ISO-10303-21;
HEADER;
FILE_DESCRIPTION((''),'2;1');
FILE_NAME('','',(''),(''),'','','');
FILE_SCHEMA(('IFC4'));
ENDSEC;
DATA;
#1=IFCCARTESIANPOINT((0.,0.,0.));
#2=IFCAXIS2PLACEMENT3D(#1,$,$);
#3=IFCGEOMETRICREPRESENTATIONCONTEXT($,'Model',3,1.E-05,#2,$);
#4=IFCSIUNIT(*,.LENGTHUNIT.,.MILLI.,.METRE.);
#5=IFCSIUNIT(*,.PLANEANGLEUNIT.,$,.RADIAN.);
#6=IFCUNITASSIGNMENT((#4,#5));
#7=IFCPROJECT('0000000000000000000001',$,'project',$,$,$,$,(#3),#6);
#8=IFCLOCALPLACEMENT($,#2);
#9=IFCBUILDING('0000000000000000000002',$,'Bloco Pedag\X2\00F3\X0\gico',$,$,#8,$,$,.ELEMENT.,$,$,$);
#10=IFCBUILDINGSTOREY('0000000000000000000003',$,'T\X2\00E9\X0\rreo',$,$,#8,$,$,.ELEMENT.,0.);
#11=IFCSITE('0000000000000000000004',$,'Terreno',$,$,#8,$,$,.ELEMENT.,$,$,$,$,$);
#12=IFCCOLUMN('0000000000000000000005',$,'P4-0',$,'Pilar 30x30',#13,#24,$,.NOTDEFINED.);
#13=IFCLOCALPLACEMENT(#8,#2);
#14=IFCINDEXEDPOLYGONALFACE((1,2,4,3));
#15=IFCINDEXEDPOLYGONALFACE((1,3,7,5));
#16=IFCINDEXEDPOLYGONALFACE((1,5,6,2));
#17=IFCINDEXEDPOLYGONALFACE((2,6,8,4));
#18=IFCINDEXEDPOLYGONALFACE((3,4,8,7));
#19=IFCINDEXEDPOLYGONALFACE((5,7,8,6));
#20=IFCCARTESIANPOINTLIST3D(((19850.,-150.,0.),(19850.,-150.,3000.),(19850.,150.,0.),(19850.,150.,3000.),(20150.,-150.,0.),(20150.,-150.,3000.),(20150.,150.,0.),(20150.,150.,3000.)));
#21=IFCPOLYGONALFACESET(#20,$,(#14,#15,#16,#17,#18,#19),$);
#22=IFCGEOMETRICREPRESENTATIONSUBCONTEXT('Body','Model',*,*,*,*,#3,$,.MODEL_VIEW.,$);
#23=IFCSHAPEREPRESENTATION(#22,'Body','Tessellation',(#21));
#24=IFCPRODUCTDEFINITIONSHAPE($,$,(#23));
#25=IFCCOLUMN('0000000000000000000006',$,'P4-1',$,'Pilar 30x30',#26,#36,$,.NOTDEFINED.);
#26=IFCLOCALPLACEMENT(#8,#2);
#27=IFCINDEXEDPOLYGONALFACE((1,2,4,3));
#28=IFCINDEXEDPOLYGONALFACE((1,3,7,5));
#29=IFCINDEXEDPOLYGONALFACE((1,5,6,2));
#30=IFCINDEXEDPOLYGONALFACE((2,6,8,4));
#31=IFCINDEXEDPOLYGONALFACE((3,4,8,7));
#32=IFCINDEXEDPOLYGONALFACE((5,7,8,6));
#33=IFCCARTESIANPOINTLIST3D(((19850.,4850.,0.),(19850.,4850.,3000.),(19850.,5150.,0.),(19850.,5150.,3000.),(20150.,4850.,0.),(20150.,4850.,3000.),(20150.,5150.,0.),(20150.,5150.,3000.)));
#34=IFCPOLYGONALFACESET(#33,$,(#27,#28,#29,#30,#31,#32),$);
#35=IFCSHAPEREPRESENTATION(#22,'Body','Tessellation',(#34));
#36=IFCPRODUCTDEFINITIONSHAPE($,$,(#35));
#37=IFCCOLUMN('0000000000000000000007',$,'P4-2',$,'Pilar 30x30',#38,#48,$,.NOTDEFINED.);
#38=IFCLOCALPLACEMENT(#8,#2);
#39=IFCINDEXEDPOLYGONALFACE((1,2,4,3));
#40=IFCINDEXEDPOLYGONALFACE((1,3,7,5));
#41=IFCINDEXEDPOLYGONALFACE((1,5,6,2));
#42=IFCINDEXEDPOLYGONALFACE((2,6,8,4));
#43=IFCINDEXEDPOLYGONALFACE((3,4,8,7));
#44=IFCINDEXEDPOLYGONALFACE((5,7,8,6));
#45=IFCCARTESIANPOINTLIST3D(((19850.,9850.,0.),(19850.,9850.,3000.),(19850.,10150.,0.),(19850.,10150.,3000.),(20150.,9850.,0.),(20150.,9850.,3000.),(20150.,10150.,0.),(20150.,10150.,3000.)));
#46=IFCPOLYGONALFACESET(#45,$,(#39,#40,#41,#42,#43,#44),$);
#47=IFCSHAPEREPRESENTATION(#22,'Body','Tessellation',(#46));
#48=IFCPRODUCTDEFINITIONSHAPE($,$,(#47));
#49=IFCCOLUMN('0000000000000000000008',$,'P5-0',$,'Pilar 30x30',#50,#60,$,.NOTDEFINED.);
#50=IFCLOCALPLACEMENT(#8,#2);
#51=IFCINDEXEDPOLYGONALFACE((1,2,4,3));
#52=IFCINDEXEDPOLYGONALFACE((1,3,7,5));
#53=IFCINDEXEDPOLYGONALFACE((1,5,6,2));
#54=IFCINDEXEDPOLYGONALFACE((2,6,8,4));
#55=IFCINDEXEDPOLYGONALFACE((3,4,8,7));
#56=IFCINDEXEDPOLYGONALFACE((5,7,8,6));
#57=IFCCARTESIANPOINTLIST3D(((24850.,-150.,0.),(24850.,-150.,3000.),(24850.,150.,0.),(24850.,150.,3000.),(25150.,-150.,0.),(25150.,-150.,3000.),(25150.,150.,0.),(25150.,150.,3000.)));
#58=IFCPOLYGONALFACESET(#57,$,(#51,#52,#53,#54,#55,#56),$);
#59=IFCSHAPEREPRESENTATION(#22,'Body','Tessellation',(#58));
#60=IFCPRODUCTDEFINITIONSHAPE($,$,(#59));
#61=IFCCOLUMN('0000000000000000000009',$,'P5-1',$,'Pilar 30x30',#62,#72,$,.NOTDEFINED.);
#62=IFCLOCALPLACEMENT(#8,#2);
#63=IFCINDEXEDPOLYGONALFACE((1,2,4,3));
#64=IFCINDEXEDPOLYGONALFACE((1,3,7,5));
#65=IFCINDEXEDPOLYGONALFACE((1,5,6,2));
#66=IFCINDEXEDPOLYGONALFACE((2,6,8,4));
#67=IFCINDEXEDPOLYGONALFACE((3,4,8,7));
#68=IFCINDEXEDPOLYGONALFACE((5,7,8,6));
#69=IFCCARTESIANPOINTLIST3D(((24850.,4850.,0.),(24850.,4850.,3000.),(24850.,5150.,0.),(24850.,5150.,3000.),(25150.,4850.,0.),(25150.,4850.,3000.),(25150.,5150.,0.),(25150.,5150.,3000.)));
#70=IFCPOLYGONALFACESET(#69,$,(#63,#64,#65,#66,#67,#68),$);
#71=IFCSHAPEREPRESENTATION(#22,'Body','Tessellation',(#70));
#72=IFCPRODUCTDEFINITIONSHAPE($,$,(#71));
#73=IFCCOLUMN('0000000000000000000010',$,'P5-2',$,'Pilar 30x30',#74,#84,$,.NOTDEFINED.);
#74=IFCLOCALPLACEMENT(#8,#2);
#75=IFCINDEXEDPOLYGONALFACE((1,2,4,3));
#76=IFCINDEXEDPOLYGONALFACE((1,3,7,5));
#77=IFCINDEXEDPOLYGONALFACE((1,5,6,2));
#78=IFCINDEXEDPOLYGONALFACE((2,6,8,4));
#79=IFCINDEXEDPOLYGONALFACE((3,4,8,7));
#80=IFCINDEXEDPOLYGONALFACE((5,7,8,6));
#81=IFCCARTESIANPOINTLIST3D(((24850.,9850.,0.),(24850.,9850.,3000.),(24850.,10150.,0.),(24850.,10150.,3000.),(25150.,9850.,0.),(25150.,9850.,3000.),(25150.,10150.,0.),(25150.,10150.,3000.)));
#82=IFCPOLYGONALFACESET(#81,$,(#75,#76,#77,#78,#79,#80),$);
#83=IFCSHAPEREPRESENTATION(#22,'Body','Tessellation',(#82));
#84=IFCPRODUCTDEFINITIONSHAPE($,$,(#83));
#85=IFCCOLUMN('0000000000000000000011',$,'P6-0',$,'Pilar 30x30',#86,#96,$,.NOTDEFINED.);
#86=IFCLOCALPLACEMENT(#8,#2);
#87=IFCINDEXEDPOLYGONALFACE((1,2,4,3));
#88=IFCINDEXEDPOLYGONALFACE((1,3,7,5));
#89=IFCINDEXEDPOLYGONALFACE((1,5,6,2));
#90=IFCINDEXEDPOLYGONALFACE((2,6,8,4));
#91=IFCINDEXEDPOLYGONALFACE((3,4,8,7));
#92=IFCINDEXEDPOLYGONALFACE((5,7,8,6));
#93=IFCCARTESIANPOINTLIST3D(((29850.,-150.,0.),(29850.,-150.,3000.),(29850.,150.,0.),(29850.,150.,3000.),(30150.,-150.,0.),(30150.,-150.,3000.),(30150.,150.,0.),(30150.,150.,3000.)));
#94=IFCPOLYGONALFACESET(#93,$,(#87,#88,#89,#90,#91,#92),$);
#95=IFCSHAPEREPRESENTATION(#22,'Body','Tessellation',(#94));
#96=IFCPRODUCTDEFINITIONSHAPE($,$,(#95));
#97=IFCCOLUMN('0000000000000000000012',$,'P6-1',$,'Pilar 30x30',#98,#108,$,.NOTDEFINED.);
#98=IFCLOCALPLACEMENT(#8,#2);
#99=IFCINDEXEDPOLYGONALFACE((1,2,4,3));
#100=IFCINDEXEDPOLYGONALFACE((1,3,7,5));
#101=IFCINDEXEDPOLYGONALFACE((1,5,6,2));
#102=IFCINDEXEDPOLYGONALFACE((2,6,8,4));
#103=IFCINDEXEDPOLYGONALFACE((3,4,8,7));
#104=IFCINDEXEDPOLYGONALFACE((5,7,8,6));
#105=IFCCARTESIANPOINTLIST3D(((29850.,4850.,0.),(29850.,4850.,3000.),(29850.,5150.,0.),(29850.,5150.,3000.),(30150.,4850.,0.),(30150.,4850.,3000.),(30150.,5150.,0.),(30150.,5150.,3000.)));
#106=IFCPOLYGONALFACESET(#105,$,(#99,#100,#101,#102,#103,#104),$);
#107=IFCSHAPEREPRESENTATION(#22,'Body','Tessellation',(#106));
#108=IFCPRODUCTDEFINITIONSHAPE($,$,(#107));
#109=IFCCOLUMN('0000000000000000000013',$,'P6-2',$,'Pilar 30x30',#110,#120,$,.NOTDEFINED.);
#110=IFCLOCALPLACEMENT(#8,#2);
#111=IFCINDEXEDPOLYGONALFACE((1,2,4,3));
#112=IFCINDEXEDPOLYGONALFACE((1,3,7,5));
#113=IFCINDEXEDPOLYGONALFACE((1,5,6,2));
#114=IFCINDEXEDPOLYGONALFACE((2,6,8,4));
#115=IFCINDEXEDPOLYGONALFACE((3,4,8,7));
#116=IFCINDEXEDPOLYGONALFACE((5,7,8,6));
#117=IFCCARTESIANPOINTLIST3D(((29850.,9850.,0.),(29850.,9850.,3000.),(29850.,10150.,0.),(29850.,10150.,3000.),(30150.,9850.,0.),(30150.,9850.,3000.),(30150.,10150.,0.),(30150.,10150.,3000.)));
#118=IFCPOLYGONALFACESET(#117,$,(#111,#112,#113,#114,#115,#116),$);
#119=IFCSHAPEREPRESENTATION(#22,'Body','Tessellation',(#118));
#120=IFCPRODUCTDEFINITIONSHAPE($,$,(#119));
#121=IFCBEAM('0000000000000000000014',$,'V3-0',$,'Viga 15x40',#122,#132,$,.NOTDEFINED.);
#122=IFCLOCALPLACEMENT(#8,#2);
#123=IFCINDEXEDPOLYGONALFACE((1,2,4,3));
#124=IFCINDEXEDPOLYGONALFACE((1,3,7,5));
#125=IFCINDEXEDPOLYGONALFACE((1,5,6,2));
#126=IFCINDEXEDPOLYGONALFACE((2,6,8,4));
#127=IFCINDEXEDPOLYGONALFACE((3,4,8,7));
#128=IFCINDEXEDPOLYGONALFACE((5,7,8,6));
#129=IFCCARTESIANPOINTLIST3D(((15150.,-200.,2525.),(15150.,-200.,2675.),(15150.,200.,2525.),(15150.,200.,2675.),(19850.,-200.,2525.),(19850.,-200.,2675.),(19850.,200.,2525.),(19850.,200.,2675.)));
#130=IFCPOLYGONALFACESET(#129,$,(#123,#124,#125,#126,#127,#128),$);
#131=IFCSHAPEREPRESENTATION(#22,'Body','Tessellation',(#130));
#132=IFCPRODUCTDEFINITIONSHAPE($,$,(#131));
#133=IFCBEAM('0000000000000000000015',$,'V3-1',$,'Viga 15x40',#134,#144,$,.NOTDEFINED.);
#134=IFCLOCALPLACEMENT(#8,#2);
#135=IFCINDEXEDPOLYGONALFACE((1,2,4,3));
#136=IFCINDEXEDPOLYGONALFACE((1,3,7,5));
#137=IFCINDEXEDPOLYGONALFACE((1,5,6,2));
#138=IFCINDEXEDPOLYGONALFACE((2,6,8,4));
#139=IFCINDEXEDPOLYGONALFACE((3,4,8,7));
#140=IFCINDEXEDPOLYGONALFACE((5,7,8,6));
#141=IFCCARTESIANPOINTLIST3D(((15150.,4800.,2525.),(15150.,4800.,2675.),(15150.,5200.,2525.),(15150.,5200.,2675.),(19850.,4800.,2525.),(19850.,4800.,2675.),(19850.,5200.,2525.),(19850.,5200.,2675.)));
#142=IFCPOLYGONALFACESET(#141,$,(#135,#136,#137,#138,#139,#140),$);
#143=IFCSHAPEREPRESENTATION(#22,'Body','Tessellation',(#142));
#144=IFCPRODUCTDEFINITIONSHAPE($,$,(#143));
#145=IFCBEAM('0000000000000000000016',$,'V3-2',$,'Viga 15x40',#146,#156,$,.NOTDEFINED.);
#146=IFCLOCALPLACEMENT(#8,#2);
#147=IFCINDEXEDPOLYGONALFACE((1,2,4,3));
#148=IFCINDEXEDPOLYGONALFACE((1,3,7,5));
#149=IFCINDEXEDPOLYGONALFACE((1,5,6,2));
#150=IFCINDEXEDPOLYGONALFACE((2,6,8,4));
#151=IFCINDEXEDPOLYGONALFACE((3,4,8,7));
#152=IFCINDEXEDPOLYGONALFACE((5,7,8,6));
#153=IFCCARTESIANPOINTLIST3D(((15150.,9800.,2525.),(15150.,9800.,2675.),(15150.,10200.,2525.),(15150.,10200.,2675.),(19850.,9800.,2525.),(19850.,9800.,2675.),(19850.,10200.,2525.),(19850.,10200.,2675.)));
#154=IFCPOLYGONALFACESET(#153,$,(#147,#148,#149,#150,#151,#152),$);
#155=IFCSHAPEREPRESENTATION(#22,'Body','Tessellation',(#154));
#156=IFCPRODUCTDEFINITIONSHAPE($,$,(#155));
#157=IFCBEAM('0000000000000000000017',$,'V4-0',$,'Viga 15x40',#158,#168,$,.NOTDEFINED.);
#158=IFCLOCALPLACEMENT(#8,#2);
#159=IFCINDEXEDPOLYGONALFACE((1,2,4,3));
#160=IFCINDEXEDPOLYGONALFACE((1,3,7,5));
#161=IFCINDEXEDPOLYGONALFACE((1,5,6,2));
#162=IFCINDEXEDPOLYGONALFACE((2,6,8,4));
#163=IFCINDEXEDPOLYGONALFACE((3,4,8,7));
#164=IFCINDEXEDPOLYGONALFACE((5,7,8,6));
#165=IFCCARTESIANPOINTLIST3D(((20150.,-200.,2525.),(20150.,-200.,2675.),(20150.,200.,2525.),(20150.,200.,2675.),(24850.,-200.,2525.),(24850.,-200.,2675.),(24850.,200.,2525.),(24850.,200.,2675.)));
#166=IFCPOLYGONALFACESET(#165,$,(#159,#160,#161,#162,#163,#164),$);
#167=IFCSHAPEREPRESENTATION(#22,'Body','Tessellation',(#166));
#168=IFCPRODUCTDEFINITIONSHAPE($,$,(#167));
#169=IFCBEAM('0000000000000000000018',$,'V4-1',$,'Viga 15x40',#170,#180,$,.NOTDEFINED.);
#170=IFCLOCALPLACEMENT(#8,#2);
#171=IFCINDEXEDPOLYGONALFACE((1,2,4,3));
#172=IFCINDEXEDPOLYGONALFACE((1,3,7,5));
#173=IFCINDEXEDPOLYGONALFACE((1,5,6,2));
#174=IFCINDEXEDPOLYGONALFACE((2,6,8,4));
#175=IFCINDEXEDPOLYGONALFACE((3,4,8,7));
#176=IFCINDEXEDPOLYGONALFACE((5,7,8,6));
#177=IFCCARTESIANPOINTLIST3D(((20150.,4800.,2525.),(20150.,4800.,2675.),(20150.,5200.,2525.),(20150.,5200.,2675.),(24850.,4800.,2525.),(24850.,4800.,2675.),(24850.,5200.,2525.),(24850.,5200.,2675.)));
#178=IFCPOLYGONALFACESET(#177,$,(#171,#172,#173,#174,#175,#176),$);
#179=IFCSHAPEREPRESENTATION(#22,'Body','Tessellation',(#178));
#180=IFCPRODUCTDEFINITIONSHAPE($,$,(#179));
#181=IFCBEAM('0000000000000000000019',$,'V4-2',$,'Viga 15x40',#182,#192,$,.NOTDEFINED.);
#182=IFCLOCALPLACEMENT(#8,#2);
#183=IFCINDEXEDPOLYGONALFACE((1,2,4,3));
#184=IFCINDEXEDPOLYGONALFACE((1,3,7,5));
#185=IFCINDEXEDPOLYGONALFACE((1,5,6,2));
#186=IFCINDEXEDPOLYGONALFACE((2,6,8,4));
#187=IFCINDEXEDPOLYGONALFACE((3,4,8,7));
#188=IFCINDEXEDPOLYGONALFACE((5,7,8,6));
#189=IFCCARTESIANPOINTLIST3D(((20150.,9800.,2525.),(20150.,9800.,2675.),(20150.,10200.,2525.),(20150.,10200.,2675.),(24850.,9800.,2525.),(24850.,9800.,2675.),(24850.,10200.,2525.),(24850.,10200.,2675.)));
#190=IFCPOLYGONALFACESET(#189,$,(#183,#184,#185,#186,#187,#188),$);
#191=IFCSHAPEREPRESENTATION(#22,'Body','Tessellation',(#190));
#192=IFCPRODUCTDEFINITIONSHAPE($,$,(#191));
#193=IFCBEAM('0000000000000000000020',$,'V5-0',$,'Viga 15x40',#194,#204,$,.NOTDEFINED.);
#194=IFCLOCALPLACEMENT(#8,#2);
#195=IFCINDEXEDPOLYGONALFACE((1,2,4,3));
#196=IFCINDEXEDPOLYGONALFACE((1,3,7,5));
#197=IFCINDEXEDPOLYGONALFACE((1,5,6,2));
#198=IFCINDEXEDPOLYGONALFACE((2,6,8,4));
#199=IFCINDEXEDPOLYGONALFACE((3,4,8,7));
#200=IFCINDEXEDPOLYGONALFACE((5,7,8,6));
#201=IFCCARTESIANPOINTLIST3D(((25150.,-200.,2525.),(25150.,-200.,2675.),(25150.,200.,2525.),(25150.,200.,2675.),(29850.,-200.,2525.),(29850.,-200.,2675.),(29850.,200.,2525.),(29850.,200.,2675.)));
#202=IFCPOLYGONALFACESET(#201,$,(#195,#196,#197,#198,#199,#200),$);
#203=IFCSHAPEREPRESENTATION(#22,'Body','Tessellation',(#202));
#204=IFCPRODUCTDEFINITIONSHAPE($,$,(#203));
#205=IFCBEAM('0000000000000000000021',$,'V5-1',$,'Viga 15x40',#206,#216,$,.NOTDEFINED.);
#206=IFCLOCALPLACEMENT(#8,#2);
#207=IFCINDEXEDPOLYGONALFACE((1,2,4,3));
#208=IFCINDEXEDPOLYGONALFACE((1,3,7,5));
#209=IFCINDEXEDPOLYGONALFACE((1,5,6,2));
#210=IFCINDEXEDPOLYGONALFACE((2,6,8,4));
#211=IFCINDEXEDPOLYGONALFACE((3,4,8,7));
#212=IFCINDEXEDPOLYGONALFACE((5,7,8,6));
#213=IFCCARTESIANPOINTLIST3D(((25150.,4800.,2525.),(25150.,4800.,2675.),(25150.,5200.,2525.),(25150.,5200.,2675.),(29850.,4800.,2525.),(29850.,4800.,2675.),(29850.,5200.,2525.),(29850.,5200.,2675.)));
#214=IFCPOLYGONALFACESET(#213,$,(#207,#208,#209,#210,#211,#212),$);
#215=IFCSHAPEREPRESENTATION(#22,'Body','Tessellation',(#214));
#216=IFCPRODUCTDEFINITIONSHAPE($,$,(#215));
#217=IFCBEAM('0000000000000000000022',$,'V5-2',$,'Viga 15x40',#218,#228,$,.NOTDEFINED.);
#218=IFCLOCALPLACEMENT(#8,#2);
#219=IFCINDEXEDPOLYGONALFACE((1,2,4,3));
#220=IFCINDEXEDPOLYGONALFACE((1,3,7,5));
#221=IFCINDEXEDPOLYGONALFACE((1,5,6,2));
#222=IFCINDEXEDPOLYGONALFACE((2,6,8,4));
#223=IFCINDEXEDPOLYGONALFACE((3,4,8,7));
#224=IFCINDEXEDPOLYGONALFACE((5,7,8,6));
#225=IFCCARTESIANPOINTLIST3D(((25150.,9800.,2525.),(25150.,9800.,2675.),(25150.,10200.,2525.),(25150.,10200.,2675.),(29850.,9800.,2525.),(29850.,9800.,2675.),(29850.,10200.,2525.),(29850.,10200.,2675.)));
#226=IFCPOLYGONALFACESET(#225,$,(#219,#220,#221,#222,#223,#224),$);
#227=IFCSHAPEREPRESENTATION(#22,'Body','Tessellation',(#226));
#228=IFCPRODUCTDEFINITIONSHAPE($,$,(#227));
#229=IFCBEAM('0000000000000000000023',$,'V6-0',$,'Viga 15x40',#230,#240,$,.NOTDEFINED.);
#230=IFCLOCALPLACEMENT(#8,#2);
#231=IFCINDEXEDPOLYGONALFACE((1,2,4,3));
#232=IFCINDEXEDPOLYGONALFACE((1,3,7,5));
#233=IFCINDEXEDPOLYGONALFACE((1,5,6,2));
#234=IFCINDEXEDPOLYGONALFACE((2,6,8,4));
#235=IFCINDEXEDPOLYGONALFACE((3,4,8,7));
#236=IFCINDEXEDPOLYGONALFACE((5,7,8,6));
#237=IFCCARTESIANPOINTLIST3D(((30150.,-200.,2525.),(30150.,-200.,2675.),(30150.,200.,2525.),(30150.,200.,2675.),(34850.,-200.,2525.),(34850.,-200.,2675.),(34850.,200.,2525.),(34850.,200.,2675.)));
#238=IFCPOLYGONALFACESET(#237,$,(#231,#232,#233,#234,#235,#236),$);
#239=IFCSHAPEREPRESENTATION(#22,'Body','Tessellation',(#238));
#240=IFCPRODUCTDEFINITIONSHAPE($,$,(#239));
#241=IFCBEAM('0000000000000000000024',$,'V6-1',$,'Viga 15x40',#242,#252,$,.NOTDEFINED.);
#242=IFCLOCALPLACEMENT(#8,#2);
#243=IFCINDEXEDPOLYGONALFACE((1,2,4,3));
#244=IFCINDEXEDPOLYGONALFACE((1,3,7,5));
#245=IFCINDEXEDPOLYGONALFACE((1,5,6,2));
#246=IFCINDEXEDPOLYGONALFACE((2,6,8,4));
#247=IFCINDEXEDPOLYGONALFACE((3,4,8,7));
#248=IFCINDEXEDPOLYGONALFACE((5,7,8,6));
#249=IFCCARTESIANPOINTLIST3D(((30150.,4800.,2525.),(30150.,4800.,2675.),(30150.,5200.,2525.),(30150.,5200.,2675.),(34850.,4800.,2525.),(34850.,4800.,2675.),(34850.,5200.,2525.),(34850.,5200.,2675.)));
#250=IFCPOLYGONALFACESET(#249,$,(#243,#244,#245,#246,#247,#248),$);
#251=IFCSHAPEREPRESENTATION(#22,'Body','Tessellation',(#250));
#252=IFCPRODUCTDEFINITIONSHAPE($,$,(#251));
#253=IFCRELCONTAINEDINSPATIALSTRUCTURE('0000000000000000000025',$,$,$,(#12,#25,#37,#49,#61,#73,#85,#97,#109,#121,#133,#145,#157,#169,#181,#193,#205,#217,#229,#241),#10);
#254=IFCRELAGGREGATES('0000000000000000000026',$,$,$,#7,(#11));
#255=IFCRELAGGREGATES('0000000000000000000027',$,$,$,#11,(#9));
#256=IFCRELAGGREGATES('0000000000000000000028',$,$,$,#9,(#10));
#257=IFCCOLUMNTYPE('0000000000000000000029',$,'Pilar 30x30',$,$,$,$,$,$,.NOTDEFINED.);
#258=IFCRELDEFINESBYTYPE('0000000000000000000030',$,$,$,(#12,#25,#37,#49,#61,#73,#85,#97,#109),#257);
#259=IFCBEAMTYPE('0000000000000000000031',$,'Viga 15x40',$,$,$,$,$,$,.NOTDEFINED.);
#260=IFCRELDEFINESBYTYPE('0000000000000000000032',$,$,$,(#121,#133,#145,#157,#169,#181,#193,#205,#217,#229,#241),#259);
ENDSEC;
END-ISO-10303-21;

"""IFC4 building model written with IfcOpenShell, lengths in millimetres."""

from ifc_helpers import new_model, si_unit, frame, origin, origin_2d, place, context, subcontext, project, spatial, rectangle, extrude, type_object, element, save


model = new_model("IFC4")

# Units and contexts
model_context = context("Model", 3, precision=1e-05, world=origin())
body_context = subcontext(model_context, "Body", "Model", "MODEL_VIEW")
ifc_project = project(units=[si_unit("LENGTHUNIT", "METRE", prefix="MILLI"), si_unit("PLANEANGLEUNIT", "RADIAN")], contexts=[model_context])

# Site, building, storey
placement = place(None, origin())
site = spatial("IfcSite", under=ifc_project, at=placement, Name="Terreno", CompositionType="ELEMENT")
building = spatial("IfcBuilding", under=site, at=placement, Name="Bloco Pedagógico", CompositionType="ELEMENT")
storey = spatial("IfcBuildingStorey", under=building, at=placement, Name="Térreo", CompositionType="ELEMENT", Elevation=0.0)

# Columns
column_type = type_object("IfcColumnType", Name="Pilar 30x30", PredefinedType="NOTDEFINED")
for number, where, z_axis, x_axis, name in (
    (1, (20000.0, 0.0, 0.0), (0.0, 0.0, 1.0), (1.0, 0.0, 0.0), "P4-0"),
    (2, (20000.0, 5000.0, 0.0), (0.0, 0.0, 1.0), (1.0, 0.0, 0.0), "P4-1"),
    (3, (20000.0, 10000.0, 0.0), (0.0, 0.0, 1.0), (1.0, 0.0, 0.0), "P4-2"),
    (4, (25000.0, 0.0, 0.0), (0.0, 0.0, 1.0), (1.0, 0.0, 0.0), "P5-0"),
    (5, (25000.0, 5000.0, 0.0), (0.0, 0.0, 1.0), (1.0, 0.0, 0.0), "P5-1"),
    (6, (25000.0, 10000.0, 0.0), (0.0, 0.0, 1.0), (1.0, 0.0, 0.0), "P5-2"),
    (7, (30000.0, 0.0, 0.0), (0.0, 0.0, 1.0), (1.0, 0.0, 0.0), "P6-0"),
    (8, (30000.0, 5000.0, 0.0), (0.0, 0.0, 1.0), (1.0, 0.0, 0.0), "P6-1"),
    (9, (30000.0, 10000.0, 0.0), (0.0, 0.0, 1.0), (1.0, 0.0, 0.0), "P6-2"),
):
    element("IfcColumn", number, at=place(None, frame(where, z_axis=z_axis, x_axis=x_axis)), inside=storey, type_object=column_type, Name=name, ObjectType="Pilar 30x30", PredefinedType="NOTDEFINED", context=body_context, shape_type="SweptSolid", body=[
        extrude(rectangle(XDim=300.0, YDim=300.0, at=origin_2d()), None, (0.0, 0.0, 1.0), 3000.0),
    ])

# Beams
beam_type = type_object("IfcBeamType", Name="Viga 15x40", PredefinedType="NOTDEFINED")
for number, where, z_axis, x_axis, name in (
    (10, (15150.0, 0.0, 2600.0), (1.0, 0.0, 0.0), (0.0, 1.0, 0.0), "V3-0"),
    (11, (15150.0, 5000.0, 2600.0), (1.0, 0.0, 0.0), (0.0, 1.0, 0.0), "V3-1"),
    (12, (15150.0, 10000.0, 2600.0), (1.0, 0.0, 0.0), (0.0, 1.0, 0.0), "V3-2"),
    (13, (20150.0, 0.0, 2600.0), (1.0, 0.0, 0.0), (0.0, 1.0, 0.0), "V4-0"),
    (14, (20150.0, 5000.0, 2600.0), (1.0, 0.0, 0.0), (0.0, 1.0, 0.0), "V4-1"),
    (15, (20150.0, 10000.0, 2600.0), (1.0, 0.0, 0.0), (0.0, 1.0, 0.0), "V4-2"),
    (16, (25150.0, 0.0, 2600.0), (1.0, 0.0, 0.0), (0.0, 1.0, 0.0), "V5-0"),
    (17, (25150.0, 5000.0, 2600.0), (1.0, 0.0, 0.0), (0.0, 1.0, 0.0), "V5-1"),
    (18, (25150.0, 10000.0, 2600.0), (1.0, 0.0, 0.0), (0.0, 1.0, 0.0), "V5-2"),
    (19, (30150.0, 0.0, 2600.0), (1.0, 0.0, 0.0), (0.0, 1.0, 0.0), "V6-0"),
    (20, (30150.0, 5000.0, 2600.0), (1.0, 0.0, 0.0), (0.0, 1.0, 0.0), "V6-1"),
):
    element("IfcBeam", number, at=place(None, frame(where, z_axis=z_axis, x_axis=x_axis)), inside=storey, type_object=beam_type, Name=name, ObjectType="Viga 15x40", PredefinedType="NOTDEFINED", context=body_context, shape_type="SweptSolid", body=[
        extrude(rectangle(XDim=400.0, YDim=150.0, at=origin_2d()), None, (0.0, 0.0, 1.0), 4700.0),
    ])

save(model, "model.ifc")
